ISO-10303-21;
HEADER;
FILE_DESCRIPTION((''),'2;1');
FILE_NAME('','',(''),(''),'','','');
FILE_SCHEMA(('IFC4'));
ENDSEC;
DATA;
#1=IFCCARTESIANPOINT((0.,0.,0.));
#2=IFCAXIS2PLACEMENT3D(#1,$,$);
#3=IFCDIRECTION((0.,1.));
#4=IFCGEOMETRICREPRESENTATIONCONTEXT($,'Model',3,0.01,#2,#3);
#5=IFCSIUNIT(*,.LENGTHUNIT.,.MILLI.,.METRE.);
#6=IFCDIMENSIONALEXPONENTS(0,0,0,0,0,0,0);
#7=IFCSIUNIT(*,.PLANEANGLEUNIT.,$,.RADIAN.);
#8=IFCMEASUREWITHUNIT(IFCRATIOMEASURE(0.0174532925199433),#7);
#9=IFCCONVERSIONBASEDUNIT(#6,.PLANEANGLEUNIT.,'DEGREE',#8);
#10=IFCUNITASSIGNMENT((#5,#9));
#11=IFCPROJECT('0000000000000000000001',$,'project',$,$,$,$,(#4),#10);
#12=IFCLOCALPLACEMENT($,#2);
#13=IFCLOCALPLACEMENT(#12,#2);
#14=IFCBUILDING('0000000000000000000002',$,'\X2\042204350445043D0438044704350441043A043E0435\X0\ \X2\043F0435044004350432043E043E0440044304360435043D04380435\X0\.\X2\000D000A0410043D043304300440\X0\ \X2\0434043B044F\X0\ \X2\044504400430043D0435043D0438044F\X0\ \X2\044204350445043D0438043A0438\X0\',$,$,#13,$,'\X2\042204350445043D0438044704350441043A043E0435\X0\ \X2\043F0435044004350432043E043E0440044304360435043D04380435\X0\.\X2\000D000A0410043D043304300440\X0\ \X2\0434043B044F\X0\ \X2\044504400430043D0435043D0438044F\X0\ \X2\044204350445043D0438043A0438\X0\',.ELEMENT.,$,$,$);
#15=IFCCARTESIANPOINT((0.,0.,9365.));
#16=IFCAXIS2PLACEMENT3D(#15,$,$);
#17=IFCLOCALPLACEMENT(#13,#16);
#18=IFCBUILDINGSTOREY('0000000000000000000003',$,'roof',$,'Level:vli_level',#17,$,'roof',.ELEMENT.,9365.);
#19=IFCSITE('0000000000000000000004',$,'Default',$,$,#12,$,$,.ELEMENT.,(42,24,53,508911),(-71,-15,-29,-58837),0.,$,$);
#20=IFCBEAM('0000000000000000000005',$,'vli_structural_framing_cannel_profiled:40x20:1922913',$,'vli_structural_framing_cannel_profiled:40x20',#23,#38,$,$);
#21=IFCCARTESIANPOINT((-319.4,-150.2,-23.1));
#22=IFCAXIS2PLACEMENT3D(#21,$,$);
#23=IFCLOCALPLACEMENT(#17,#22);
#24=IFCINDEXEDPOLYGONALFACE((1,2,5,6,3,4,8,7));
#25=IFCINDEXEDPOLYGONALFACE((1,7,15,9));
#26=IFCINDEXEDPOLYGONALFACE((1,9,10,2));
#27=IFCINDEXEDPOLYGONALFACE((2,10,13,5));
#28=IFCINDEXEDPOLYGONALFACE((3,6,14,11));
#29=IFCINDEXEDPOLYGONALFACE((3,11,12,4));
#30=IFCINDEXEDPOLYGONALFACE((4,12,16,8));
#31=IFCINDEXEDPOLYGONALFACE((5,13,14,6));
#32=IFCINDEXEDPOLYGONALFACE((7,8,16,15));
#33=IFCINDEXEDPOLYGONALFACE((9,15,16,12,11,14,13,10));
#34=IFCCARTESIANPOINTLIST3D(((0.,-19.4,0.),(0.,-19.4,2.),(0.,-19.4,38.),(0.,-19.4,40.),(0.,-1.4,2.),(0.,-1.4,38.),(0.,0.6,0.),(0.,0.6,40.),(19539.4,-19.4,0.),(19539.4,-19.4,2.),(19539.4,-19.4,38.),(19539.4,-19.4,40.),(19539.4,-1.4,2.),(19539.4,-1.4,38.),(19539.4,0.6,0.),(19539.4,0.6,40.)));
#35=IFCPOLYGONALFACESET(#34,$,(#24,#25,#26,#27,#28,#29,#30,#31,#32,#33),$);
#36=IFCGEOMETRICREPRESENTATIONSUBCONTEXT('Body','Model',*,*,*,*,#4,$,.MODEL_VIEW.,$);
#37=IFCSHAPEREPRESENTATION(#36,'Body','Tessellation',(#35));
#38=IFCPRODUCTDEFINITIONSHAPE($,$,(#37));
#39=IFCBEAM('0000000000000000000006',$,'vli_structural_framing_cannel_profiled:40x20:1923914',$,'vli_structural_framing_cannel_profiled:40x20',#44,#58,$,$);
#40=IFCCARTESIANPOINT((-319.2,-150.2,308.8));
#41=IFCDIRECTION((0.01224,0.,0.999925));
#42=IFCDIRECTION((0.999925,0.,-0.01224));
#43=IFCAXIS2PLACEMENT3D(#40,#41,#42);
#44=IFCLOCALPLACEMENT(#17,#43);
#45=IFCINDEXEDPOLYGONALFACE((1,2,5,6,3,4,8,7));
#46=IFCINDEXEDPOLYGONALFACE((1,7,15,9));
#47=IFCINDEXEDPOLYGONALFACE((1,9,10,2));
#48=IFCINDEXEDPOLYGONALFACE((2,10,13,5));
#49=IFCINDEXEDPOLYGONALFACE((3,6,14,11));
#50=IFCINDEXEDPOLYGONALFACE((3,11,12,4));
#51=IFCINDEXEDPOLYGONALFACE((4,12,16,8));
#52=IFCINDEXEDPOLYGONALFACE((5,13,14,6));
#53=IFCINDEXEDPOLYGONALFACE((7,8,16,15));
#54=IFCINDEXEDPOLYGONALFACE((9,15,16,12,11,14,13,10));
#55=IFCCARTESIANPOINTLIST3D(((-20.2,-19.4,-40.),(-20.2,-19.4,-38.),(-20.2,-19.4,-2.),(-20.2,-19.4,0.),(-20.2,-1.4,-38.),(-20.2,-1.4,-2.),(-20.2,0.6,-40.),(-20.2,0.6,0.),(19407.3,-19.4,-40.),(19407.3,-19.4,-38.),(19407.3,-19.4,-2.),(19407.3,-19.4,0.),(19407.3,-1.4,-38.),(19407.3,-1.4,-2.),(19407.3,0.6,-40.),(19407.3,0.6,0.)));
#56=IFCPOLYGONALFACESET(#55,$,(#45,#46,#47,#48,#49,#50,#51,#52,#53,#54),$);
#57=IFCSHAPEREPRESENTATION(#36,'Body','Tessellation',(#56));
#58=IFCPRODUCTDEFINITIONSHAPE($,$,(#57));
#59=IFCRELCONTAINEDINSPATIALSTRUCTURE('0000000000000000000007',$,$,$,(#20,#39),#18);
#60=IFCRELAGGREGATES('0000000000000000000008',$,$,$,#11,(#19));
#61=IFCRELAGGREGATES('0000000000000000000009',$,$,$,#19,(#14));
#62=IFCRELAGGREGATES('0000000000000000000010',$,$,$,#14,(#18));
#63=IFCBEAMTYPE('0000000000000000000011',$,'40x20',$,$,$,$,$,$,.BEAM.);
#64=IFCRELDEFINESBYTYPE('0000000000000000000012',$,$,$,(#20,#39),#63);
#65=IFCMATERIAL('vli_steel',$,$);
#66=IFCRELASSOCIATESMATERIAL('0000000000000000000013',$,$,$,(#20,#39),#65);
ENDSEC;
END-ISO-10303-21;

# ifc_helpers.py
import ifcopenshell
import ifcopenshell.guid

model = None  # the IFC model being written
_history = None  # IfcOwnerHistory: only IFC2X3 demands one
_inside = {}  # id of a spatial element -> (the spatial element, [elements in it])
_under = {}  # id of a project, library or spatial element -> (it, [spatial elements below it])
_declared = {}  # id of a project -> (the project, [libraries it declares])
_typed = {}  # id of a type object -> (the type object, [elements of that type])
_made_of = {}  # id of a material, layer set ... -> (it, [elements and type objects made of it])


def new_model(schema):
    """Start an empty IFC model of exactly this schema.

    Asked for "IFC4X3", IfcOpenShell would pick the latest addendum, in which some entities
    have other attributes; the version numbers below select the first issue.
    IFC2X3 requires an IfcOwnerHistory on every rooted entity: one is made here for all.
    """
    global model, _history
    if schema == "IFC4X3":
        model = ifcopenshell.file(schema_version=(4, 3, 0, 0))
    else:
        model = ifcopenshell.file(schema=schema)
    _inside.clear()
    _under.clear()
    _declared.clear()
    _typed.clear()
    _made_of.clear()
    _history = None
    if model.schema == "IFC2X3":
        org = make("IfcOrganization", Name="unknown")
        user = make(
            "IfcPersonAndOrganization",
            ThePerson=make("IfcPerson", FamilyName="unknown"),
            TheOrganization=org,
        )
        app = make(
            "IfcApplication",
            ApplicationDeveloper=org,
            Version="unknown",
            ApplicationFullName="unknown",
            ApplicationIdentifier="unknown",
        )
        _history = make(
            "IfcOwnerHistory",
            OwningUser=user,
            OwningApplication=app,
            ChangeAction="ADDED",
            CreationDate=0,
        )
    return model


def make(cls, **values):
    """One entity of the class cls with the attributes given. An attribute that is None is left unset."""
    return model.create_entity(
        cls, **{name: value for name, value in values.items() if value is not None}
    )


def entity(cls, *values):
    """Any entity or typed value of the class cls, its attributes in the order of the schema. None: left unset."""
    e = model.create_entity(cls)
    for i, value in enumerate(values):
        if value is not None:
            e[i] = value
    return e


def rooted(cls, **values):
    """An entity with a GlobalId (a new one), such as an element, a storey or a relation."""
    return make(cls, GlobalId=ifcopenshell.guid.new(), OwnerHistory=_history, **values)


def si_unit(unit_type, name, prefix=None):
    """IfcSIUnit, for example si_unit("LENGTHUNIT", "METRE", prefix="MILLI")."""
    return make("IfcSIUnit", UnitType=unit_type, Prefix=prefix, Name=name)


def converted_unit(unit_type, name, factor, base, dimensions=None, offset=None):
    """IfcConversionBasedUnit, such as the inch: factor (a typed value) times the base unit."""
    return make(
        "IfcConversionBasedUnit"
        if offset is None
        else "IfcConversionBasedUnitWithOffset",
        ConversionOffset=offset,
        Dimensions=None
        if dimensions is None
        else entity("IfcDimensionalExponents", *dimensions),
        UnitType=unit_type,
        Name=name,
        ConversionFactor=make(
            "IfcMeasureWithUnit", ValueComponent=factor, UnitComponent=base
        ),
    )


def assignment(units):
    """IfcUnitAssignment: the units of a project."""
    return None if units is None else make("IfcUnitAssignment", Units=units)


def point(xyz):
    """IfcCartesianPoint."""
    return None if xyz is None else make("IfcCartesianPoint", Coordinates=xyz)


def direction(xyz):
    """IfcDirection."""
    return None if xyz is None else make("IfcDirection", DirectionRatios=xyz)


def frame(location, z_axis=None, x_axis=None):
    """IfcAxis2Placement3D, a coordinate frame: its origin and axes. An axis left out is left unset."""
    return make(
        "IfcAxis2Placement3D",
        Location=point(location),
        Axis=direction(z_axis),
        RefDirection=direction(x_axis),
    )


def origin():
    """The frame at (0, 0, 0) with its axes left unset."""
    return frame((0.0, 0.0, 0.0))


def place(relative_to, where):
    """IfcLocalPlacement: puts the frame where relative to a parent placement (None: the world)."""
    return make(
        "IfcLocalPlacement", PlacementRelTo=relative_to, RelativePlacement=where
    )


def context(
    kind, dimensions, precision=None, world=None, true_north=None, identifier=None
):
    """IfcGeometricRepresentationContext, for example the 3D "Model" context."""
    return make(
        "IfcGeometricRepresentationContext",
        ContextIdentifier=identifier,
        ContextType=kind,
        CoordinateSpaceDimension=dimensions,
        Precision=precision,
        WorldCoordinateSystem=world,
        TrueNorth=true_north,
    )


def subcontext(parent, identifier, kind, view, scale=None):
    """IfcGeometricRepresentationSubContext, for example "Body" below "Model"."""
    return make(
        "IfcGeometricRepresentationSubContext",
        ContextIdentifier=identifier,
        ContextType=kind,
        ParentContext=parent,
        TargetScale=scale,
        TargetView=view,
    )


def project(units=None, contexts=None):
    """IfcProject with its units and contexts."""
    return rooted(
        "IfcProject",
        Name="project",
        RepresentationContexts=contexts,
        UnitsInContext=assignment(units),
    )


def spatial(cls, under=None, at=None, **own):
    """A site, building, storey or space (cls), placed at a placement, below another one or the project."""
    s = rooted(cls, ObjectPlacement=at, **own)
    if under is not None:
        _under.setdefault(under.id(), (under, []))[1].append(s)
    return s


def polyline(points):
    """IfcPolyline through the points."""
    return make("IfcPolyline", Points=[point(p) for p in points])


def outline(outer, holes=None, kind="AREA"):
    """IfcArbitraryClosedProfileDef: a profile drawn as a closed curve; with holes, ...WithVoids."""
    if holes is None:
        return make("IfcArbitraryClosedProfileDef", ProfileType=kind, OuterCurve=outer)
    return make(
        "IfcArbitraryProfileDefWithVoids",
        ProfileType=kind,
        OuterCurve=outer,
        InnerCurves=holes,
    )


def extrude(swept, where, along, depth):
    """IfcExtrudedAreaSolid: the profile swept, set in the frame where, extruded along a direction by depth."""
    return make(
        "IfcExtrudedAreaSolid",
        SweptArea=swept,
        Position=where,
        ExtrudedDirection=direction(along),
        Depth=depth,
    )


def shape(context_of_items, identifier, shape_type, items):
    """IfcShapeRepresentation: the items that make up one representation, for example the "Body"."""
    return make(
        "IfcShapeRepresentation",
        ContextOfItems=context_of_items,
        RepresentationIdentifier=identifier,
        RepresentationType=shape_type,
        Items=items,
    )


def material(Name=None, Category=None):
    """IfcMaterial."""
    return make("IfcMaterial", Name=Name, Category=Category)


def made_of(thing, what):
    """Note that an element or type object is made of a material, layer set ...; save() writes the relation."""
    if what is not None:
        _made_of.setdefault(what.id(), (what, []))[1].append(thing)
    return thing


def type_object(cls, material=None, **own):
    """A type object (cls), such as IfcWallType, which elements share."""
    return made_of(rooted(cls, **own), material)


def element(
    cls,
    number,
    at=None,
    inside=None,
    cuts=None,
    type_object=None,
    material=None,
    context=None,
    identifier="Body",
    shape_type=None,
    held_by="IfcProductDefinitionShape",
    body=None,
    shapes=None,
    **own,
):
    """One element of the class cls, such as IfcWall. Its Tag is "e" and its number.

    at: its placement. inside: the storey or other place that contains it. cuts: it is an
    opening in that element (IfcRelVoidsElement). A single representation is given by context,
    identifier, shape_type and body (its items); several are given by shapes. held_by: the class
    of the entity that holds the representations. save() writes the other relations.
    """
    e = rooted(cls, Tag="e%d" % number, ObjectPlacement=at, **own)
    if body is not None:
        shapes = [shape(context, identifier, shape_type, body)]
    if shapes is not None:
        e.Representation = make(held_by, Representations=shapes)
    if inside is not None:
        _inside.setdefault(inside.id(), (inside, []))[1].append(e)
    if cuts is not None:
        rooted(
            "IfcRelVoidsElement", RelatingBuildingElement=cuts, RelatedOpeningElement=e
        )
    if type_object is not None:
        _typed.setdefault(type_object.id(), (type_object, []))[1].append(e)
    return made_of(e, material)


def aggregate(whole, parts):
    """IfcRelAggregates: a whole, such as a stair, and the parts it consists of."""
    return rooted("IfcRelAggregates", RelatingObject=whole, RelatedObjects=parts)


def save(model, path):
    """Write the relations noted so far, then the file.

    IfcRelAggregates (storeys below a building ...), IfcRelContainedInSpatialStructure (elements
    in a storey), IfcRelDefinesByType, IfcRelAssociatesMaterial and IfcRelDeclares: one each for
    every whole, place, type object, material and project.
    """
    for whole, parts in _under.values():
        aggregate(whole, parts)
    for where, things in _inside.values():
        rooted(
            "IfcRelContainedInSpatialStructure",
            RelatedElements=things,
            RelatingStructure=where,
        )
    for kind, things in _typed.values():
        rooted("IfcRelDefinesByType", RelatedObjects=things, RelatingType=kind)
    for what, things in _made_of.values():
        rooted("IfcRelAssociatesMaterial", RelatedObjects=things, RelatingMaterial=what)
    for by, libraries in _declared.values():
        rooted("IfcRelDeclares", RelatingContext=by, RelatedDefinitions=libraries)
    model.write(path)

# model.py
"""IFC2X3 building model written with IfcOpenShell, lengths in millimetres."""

from ifc_helpers import new_model, entity, si_unit, converted_unit, direction, frame, origin, place, context, subcontext, project, spatial, polyline, outline, extrude, material, type_object, element, save


model = new_model("IFC2X3")

# Units and contexts
model_context = context("Model", 3, precision=0.01, world=origin(), true_north=direction((0.0, 1.0)))
body_context = subcontext(model_context, "Body", "Model", "MODEL_VIEW")
ifc_project = project(units=[si_unit("LENGTHUNIT", "METRE", prefix="MILLI"), converted_unit("PLANEANGLEUNIT", "DEGREE", entity("IfcRatioMeasure", 0.0174532925199433), si_unit("PLANEANGLEUNIT", "RADIAN"), dimensions=[0, 0, 0, 0, 0, 0, 0])], contexts=[model_context])

# Site, building, storey
site_placement = place(None, origin())
site = spatial("IfcSite", under=ifc_project, at=site_placement, Name="Default", CompositionType="ELEMENT", RefLatitude=(42, 24, 53, 508911), RefLongitude=(-71, -15, -29, -58837), RefElevation=0.0)
building_placement = place(site_placement, origin())
building = spatial("IfcBuilding", under=site, at=building_placement, Name="Техническое перевооружение.\r\nАнгар для хранения техники", LongName="Техническое перевооружение.\r\nАнгар для хранения техники", CompositionType="ELEMENT")
storey_placement = place(building_placement, frame((0.0, 0.0, 9365.0)))
storey = spatial("IfcBuildingStorey", under=building, at=storey_placement, Name="roof", ObjectType="Level:vli_level", LongName="roof", CompositionType="ELEMENT", Elevation=9365.0)

# Beams
ifc_material = material(Name="vli_steel")
beam_type = type_object("IfcBeamType", Name="40x20", PredefinedType="BEAM")
beam_1_placement = place(storey_placement, frame((-319.4, -150.2, -23.1)))
element("IfcBeam", 1, at=beam_1_placement, inside=storey, type_object=beam_type, material=ifc_material, Name="vli_structural_framing_cannel_profiled:40x20:1922913", ObjectType="vli_structural_framing_cannel_profiled:40x20", context=body_context, shape_type="SweptSolid", body=[
    extrude(outline(polyline([(-20.0, -9.5), (-18.0, -9.5), (-18.0, 8.5), (18.0, 8.5), (18.0, -9.5), (20.0, -9.5), (20.0, 10.5), (-20.0, 10.5), (-20.0, -9.5)])), frame((0.0, -9.9, 20.0), z_axis=(1.0, 0.0, 0.0), x_axis=(0.0, 0.0, -1.0)), (0.0, 0.0, 1.0), 19539.4),
])
beam_2_placement = place(storey_placement, frame((-319.2, -150.2, 308.8), z_axis=(0.01224, 0.0, 0.999925), x_axis=(0.999925, 0.0, -0.01224)))
element("IfcBeam", 2, at=beam_2_placement, inside=storey, type_object=beam_type, material=ifc_material, Name="vli_structural_framing_cannel_profiled:40x20:1923914", ObjectType="vli_structural_framing_cannel_profiled:40x20", context=body_context, shape_type="SweptSolid", body=[
    extrude(outline(polyline([(-20.0, -9.5), (-18.0, -9.5), (-18.0, 8.5), (18.0, 8.5), (18.0, -9.5), (20.0, -9.5), (20.0, 10.5), (-20.0, 10.5), (-20.0, -9.5)])), frame((-20.2, -9.9, -20.0), z_axis=(1.0, 0.0, 0.0), x_axis=(0.0, 0.0, -1.0)), (0.0, 0.0, 1.0), 19427.6),
])

save(model, "model.ifc")
